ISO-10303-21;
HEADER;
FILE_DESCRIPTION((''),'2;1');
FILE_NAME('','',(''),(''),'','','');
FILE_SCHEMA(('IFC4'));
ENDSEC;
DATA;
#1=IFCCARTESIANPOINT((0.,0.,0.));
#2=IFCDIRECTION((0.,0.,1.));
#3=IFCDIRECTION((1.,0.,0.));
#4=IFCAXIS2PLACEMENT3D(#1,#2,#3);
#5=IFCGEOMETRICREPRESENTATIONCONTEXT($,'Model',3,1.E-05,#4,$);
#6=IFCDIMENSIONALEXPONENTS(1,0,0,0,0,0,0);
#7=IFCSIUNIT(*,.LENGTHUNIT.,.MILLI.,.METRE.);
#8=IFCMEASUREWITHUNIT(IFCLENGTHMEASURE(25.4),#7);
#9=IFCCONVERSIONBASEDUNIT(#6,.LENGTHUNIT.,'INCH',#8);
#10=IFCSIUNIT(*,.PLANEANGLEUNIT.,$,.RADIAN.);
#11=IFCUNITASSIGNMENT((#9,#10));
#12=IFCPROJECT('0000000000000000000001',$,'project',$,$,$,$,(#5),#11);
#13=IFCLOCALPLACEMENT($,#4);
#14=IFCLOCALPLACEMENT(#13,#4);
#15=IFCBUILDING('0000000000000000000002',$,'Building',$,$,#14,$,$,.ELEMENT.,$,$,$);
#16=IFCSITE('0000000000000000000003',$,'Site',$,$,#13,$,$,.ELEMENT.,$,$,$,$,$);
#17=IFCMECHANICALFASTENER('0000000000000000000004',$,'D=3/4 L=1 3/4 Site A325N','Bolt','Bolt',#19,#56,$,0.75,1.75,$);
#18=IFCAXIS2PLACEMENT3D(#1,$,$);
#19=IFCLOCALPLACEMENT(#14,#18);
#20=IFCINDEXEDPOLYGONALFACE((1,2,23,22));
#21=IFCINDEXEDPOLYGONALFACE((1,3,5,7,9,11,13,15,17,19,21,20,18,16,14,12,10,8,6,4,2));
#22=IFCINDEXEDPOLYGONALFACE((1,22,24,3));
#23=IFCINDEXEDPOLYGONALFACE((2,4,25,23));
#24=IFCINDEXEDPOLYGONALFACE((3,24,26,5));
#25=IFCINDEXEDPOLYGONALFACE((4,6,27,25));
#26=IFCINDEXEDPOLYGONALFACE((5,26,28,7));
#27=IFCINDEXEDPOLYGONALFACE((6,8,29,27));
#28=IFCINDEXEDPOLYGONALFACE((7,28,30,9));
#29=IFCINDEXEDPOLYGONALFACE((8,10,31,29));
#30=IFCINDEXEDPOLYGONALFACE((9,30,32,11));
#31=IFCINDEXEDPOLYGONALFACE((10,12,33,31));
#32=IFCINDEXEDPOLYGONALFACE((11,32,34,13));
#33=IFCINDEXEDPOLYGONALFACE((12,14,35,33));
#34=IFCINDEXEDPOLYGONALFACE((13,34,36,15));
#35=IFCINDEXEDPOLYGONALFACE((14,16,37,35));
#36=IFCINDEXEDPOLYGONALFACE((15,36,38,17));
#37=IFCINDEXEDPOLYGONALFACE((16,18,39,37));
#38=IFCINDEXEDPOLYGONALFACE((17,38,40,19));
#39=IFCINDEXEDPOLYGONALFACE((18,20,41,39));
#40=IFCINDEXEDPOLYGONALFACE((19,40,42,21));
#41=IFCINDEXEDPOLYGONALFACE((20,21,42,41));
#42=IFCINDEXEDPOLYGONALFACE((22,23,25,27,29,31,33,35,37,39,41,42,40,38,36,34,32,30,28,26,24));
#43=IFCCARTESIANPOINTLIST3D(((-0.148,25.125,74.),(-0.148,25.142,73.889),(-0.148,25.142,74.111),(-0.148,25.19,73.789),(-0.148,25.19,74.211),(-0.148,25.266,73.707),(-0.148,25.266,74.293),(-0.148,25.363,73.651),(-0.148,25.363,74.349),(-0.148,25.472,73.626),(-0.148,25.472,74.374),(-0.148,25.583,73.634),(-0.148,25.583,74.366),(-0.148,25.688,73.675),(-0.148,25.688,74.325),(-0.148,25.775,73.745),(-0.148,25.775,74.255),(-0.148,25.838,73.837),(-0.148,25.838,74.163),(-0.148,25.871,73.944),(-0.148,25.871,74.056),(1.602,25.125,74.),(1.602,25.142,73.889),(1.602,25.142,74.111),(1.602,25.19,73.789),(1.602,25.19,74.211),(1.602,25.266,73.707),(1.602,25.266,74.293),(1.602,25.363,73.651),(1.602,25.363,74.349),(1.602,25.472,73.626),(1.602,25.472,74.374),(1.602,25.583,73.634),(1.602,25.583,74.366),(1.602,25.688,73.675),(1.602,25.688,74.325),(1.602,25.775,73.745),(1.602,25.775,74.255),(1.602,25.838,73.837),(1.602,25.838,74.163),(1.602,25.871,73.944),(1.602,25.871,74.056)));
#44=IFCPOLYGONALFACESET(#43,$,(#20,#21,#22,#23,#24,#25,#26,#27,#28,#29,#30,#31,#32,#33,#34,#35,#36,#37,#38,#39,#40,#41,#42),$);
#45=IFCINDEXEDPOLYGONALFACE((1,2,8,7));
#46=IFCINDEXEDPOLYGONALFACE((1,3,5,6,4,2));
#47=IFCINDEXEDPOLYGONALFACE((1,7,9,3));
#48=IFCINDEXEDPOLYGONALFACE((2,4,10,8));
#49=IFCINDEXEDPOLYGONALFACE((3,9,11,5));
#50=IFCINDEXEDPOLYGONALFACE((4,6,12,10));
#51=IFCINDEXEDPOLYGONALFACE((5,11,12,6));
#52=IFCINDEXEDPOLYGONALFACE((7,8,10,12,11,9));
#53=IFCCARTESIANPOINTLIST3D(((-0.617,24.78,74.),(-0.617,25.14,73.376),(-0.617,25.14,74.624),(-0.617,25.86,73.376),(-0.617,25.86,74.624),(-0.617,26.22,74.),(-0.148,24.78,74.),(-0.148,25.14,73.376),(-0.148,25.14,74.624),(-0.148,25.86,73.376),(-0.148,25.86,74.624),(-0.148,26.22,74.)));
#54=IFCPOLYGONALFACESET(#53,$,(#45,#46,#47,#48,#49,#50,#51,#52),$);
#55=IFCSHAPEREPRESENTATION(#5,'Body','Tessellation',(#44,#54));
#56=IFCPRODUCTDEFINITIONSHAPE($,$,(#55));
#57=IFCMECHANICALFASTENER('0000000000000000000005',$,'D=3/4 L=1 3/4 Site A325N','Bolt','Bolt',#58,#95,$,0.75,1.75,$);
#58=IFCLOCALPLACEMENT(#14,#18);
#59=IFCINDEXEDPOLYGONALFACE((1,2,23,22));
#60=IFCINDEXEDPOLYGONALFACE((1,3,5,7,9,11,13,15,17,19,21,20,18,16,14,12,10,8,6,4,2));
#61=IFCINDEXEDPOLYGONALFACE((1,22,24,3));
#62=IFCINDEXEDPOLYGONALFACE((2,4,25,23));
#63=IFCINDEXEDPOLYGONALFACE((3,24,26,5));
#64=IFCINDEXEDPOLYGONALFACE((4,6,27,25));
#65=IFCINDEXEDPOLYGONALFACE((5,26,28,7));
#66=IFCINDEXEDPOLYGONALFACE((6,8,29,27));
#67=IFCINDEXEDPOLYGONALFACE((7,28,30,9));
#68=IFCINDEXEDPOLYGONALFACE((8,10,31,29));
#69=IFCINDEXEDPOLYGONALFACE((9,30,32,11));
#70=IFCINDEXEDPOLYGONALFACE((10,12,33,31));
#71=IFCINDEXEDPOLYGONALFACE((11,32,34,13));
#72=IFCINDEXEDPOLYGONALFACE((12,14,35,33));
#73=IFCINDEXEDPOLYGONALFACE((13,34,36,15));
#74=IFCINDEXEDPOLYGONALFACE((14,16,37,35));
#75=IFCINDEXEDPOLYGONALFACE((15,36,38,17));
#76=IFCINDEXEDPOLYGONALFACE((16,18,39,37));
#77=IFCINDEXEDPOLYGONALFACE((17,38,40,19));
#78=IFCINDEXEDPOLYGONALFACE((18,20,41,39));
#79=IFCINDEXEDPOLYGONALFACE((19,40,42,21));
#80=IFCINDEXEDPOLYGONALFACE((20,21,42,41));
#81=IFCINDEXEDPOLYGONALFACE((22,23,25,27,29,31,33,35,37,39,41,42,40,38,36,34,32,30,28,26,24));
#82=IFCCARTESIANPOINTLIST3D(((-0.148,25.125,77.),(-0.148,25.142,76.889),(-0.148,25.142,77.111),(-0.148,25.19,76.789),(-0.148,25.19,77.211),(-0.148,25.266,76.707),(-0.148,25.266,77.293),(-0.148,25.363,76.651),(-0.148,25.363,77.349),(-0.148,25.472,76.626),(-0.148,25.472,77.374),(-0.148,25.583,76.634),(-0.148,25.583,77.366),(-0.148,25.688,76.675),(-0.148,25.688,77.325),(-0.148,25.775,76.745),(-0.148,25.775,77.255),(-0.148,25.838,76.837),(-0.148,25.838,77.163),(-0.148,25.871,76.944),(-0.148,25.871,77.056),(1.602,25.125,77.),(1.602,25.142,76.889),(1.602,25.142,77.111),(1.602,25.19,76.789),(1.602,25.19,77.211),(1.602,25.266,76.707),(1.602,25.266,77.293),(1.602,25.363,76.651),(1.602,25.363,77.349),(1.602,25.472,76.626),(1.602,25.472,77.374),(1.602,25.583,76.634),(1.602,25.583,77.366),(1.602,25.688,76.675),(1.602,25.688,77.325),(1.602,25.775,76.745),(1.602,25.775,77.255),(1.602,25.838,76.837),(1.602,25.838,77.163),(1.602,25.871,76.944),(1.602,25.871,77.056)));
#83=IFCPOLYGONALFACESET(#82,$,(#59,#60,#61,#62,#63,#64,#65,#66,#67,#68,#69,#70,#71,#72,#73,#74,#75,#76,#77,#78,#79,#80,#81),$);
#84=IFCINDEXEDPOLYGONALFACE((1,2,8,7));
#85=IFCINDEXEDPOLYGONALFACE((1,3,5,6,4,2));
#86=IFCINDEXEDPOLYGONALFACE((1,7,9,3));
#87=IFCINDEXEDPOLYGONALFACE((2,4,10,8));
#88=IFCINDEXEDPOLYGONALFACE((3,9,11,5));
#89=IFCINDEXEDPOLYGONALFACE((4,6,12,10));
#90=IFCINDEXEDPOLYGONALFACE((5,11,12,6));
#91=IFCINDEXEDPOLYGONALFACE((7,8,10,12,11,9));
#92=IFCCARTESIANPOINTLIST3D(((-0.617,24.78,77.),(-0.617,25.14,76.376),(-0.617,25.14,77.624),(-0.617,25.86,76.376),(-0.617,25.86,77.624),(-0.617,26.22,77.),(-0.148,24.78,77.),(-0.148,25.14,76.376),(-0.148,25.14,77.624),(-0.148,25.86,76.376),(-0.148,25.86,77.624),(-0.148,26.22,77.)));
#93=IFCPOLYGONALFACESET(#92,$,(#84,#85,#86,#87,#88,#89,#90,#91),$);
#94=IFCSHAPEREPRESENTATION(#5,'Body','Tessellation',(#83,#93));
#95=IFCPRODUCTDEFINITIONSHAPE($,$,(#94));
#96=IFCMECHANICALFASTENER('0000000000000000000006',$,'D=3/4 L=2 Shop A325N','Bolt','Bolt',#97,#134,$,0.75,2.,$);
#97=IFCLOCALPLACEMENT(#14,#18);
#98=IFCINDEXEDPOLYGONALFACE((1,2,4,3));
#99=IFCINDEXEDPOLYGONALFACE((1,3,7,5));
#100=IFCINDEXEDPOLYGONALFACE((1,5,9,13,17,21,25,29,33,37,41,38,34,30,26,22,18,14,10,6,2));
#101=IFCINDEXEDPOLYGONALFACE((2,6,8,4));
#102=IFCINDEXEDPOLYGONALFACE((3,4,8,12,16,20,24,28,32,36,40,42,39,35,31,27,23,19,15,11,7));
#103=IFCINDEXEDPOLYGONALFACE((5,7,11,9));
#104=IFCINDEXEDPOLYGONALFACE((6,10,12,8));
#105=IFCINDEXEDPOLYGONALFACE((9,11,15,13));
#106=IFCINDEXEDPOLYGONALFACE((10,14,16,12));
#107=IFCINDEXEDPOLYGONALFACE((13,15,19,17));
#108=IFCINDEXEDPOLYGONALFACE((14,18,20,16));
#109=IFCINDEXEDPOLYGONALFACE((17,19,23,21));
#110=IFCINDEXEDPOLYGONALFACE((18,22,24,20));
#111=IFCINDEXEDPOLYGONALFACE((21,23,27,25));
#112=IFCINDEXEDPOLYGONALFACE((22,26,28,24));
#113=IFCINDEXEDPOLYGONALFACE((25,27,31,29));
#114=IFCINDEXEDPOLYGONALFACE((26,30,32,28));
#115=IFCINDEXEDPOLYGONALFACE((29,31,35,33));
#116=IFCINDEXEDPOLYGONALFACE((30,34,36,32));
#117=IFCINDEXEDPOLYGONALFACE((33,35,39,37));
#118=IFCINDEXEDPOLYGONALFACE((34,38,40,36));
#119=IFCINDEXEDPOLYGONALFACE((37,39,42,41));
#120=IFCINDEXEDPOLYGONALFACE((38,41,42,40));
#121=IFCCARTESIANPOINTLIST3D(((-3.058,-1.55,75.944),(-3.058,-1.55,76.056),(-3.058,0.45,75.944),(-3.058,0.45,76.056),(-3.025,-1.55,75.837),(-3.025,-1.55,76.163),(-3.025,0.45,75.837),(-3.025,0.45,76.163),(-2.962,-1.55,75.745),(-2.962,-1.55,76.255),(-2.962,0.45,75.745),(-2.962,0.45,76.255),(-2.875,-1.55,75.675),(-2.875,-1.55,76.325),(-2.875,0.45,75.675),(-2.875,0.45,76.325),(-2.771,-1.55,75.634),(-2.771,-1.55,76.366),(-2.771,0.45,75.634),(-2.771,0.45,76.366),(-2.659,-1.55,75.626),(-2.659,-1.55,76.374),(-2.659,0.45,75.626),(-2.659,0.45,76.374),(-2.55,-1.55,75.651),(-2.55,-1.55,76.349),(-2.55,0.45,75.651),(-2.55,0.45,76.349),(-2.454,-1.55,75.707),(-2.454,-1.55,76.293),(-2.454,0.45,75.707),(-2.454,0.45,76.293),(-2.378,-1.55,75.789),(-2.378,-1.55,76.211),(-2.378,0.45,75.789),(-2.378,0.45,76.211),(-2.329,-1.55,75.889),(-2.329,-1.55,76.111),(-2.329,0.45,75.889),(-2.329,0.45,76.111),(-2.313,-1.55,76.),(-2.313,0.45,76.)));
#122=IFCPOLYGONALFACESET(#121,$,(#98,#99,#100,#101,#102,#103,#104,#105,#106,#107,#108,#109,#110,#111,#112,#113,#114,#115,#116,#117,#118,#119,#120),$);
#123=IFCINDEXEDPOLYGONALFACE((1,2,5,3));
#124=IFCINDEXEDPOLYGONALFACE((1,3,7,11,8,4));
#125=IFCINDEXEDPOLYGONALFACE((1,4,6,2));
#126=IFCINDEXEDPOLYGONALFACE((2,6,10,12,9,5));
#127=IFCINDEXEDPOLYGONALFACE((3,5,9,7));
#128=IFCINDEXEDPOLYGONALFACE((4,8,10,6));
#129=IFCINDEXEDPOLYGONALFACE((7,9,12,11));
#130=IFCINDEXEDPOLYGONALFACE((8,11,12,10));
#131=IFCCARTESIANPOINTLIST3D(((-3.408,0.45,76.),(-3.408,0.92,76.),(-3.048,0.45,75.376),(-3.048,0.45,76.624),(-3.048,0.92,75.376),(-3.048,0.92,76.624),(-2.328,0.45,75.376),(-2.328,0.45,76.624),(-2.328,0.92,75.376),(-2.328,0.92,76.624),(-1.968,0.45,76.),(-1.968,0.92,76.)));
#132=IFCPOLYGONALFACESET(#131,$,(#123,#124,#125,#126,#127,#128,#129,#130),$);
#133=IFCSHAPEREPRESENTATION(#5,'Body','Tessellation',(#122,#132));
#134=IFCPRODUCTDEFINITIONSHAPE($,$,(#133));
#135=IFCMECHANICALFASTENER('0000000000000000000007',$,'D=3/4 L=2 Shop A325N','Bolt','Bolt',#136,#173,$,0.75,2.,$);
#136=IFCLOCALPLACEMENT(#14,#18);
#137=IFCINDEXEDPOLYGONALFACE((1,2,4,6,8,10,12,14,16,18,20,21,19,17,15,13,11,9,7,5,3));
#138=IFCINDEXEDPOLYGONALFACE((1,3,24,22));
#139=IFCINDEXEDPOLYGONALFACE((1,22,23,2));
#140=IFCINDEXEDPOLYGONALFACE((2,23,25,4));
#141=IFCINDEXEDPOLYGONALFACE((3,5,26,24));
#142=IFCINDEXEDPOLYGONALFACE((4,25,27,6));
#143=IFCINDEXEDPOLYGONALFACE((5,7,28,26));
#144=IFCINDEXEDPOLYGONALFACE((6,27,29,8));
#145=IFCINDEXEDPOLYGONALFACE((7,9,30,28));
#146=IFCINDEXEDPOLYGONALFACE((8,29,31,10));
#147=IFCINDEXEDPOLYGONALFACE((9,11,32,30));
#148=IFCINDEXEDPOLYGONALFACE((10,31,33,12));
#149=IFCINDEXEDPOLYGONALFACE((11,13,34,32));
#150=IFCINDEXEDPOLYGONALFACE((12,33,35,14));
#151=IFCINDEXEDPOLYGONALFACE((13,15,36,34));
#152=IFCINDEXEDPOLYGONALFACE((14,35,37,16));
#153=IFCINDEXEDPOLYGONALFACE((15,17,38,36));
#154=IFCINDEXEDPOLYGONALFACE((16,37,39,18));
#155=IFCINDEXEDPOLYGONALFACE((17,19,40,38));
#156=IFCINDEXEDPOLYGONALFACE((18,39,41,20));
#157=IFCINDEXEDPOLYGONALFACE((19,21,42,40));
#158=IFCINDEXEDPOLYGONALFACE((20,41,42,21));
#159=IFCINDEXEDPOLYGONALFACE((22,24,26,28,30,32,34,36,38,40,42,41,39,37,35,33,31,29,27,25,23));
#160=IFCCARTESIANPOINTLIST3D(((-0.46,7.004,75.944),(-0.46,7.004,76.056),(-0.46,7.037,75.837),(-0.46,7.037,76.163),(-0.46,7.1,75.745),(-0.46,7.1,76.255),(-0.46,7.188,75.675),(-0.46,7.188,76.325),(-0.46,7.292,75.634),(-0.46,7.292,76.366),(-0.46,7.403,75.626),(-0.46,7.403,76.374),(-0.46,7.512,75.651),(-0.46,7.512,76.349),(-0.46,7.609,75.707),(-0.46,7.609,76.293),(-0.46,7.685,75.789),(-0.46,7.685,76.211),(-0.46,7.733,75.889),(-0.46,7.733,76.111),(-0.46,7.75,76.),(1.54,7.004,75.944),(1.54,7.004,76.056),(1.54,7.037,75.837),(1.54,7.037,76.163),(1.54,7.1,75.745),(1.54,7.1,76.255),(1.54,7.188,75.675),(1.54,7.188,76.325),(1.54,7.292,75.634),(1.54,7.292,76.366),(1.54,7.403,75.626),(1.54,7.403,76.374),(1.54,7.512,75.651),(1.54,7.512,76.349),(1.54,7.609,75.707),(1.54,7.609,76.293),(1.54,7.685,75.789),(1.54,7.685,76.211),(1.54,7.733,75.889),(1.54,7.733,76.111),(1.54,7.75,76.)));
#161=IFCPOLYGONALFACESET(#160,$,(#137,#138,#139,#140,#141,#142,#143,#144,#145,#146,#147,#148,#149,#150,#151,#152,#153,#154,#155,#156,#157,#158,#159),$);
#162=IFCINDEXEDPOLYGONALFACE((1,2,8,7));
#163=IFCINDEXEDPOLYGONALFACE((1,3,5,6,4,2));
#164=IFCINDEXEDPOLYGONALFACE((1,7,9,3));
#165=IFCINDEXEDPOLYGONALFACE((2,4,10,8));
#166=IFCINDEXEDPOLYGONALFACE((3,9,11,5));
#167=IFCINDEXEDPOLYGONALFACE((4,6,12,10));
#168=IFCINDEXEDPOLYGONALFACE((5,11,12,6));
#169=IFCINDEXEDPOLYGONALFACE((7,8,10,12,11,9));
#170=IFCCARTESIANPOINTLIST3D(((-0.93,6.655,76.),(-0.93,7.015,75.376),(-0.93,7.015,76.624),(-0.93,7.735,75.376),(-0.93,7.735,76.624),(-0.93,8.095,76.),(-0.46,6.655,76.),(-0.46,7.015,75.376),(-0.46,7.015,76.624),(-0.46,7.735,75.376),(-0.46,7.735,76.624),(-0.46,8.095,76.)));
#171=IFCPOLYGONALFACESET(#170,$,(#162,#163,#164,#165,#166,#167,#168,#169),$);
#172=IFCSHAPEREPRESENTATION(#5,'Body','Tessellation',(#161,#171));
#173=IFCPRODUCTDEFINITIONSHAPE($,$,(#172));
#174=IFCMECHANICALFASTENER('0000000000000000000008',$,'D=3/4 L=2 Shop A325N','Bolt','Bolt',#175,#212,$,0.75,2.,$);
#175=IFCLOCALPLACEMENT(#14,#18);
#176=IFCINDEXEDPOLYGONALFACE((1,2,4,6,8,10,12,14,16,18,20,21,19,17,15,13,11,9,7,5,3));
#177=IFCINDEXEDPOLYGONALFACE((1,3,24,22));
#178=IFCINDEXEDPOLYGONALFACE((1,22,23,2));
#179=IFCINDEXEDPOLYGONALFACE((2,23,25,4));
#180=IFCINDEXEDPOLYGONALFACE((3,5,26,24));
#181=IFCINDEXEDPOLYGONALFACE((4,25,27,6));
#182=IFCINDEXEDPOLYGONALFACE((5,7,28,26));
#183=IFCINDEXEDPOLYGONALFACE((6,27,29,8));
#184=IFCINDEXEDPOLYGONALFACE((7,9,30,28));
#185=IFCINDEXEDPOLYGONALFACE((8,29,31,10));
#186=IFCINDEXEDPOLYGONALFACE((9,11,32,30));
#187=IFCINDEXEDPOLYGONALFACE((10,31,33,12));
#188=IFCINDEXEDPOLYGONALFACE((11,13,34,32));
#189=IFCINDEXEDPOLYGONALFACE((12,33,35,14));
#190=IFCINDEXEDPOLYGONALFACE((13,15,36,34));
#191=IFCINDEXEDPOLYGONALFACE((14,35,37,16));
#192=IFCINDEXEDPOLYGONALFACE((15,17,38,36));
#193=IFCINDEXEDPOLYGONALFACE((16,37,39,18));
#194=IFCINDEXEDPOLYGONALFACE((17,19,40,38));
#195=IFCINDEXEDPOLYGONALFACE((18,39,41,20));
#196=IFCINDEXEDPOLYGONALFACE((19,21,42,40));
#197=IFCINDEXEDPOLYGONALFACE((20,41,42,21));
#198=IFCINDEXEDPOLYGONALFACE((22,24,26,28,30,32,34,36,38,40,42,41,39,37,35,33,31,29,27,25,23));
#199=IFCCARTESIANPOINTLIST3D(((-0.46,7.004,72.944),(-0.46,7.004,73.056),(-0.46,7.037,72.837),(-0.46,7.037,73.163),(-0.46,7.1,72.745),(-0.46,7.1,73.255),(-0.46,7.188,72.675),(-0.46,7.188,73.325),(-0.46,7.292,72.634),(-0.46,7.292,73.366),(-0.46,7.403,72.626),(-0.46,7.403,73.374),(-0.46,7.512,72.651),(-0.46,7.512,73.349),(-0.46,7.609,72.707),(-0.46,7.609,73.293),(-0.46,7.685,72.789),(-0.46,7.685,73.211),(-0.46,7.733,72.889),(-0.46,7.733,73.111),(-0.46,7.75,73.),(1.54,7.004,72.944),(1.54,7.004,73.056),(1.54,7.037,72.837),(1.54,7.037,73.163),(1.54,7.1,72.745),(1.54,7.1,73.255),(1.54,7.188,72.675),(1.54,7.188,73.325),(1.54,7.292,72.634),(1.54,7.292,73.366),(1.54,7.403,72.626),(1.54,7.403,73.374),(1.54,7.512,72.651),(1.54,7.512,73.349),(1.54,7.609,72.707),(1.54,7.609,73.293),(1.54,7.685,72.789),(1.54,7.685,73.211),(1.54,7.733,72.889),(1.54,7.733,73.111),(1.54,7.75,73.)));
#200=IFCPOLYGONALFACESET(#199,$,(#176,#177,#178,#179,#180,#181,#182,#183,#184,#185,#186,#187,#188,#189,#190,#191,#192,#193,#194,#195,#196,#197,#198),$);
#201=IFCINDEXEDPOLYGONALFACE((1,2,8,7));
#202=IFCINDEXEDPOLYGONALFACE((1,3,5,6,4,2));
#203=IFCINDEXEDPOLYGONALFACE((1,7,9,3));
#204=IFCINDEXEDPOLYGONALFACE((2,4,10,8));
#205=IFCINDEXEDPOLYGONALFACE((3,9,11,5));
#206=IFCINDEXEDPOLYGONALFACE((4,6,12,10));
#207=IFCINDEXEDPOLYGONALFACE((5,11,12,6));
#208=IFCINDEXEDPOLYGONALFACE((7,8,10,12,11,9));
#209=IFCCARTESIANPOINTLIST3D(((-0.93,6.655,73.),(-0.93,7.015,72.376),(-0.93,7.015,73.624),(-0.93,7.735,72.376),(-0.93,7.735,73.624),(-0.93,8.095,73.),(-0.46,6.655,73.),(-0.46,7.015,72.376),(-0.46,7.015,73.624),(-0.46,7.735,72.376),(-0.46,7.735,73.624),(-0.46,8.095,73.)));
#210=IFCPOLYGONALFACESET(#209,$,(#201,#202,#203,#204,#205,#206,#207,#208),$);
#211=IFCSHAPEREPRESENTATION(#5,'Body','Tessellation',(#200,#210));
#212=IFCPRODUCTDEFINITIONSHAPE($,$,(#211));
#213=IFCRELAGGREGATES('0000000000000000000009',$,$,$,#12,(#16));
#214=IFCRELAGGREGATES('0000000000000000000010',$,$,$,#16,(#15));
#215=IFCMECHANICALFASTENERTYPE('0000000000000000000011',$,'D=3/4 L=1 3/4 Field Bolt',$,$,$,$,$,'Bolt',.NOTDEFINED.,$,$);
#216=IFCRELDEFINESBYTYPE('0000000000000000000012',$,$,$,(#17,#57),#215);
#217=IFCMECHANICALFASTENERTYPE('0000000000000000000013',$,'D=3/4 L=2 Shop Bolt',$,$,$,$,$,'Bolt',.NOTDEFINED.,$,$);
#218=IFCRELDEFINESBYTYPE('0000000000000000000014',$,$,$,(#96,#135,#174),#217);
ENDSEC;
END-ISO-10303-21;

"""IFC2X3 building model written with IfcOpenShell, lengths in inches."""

from ifc_helpers import new_model, entity, si_unit, converted_unit, frame, origin_with_axes, origin_2d_with_axis, place, context, project, spatial, polyline, circle, outline, extrude, source, transform, mapped, type_object, type_shapes, element, save


model = new_model("IFC2X3")

# Units and contexts
model_context = context("Model", 3, precision=1e-05, world=origin_with_axes())
ifc_project = project(units=[converted_unit("LENGTHUNIT", "INCH", entity("IfcLengthMeasure", 25.4), si_unit("LENGTHUNIT", "METRE", prefix="MILLI"), dimensions=[1, 0, 0, 0, 0, 0, 0]), si_unit("PLANEANGLEUNIT", "RADIAN")], contexts=[model_context])

# Site, building
site_placement = place(None, origin_with_axes())
site = spatial("IfcSite", under=ifc_project, at=site_placement, Name="Site", CompositionType="ELEMENT")
building_placement = place(site_placement, origin_with_axes())
building = spatial("IfcBuilding", under=site, at=building_placement, Name="Building", CompositionType="ELEMENT")

# Shared definitions
assembly_1_placement = place(building_placement, frame((0.0, 0.0, 80.0), z_axis=(0.0, 0.0, 1.0), x_axis=(0.0, 1.0, 0.0)))

# Mechanical fasteners
mechanical_fastener_type_1 = type_object("IfcMechanicalFastenerType", Name="D=3/4 L=1 3/4 Field Bolt", ElementType="Bolt")
shared_shape_1 = source(origin_with_axes(), model_context, "Body", "SweptSolid", [
    extrude(circle(Radius=0.375, at=origin_2d_with_axis()), frame((0.0, 0.0, 0.0), z_axis=(1.0, 0.0, 0.0), x_axis=(0.0, 1.0, 0.0)), (0.0, 0.0, 1.0), 1.75),
    extrude(outline(polyline([(-0.72, 0.0), (-0.36, 0.624), (0.36, 0.624), (0.72, 0.0), (0.36, -0.624), (-0.36, -0.624), (-0.72, 0.0)])), frame((0.0, 0.0, 0.0), z_axis=(1.0, 0.0, 0.0), x_axis=(0.0, 1.0, 0.0)), (0.0, 0.0, -1.0), 0.47),
])
type_shapes(mechanical_fastener_type_1, [shared_shape_1])
placement_1 = place(building_placement, frame((0.0, 23.0, 82.5), z_axis=(0.0, 0.0, 1.0), x_axis=(1.0, 0.0, 0.0)))
placement_2 = place(placement_1, frame((-0.148, 2.5, -5.5), z_axis=(0.0, 0.0, -1.0), x_axis=(1.0, 0.0, 0.0)))
for number, where, z_axis, x_axis, name in (
    (1, (0.0, 0.0, 3.0), (0.0, 0.0, 1.0), (1.0, 0.0, 0.0), "D=3/4 L=1 3/4 Site A325N"),
    (2, (0.0, 0.0, 0.0), (0.0, 0.0, 1.0), (1.0, 0.0, 0.0), "D=3/4 L=1 3/4 Site A325N"),
):
    element("IfcMechanicalFastener", number, at=place(placement_2, frame(where, z_axis=z_axis, x_axis=x_axis)), type_object=mechanical_fastener_type_1, Name=name, Description="Bolt", ObjectType="Bolt", NominalDiameter=0.75, NominalLength=1.75, context=model_context, shape_type="MappedRepresentation", body=[
        mapped(shared_shape_1, transform((0.0, 0.0, 0.0), scale=1.0)),
    ])
mechanical_fastener_type_2 = type_object("IfcMechanicalFastenerType", Name="D=3/4 L=2 Shop Bolt", ElementType="Bolt")
shared_shape_2 = source(origin_with_axes(), model_context, "Body", "SweptSolid", [
    extrude(circle(Radius=0.375, at=origin_2d_with_axis()), frame((0.0, 0.0, 0.0), z_axis=(1.0, 0.0, 0.0), x_axis=(0.0, 1.0, 0.0)), (0.0, 0.0, 1.0), 2.0),
    extrude(outline(polyline([(-0.72, 0.0), (-0.36, 0.624), (0.36, 0.624), (0.72, 0.0), (0.36, -0.624), (-0.36, -0.624), (-0.72, 0.0)])), frame((0.0, 0.0, 0.0), z_axis=(1.0, 0.0, 0.0), x_axis=(0.0, 1.0, 0.0)), (0.0, 0.0, -1.0), 0.47),
])
type_shapes(mechanical_fastener_type_2, [shared_shape_2])
placement_3 = place(building_placement, frame((0.0, 0.0, 80.0), z_axis=(0.0, 0.0, 1.0), x_axis=(-1.0, 0.0, 0.0)))
placement_4 = place(placement_3, frame((2.688, -0.45, -10.0), z_axis=(0.0, 0.0, 1.0), x_axis=(0.0, 1.0, 0.0)))
mechanical_fastener_1_placement = place(placement_4, frame((0.0, 0.0, 6.0), z_axis=(0.0, 0.0, 1.0), x_axis=(1.0, 0.0, 0.0)))
element("IfcMechanicalFastener", 3, at=mechanical_fastener_1_placement, type_object=mechanical_fastener_type_2, Name="D=3/4 L=2 Shop A325N", Description="Bolt", ObjectType="Bolt", NominalDiameter=0.75, NominalLength=2.0, context=model_context, shape_type="MappedRepresentation", body=[
    mapped(shared_shape_2, transform((0.0, 0.0, 0.0), scale=1.0)),
])
placement_5 = place(assembly_1_placement, frame((7.375, 0.46, -10.0), z_axis=(0.0, 0.0, 1.0), x_axis=(0.0, -1.0, 0.0)))
for number, where, z_axis, x_axis, name in (
    (4, (0.0, 0.0, 6.0), (0.0, 0.0, 1.0), (1.0, 0.0, 0.0), "D=3/4 L=2 Shop A325N"),
    (5, (0.0, 0.0, 3.0), (0.0, 0.0, 1.0), (1.0, 0.0, 0.0), "D=3/4 L=2 Shop A325N"),
):
    element("IfcMechanicalFastener", number, at=place(placement_5, frame(where, z_axis=z_axis, x_axis=x_axis)), type_object=mechanical_fastener_type_2, Name=name, Description="Bolt", ObjectType="Bolt", NominalDiameter=0.75, NominalLength=2.0, context=model_context, shape_type="MappedRepresentation", body=[
        mapped(shared_shape_2, transform((0.0, 0.0, 0.0), scale=1.0)),
    ])

save(model, "model.ifc")
